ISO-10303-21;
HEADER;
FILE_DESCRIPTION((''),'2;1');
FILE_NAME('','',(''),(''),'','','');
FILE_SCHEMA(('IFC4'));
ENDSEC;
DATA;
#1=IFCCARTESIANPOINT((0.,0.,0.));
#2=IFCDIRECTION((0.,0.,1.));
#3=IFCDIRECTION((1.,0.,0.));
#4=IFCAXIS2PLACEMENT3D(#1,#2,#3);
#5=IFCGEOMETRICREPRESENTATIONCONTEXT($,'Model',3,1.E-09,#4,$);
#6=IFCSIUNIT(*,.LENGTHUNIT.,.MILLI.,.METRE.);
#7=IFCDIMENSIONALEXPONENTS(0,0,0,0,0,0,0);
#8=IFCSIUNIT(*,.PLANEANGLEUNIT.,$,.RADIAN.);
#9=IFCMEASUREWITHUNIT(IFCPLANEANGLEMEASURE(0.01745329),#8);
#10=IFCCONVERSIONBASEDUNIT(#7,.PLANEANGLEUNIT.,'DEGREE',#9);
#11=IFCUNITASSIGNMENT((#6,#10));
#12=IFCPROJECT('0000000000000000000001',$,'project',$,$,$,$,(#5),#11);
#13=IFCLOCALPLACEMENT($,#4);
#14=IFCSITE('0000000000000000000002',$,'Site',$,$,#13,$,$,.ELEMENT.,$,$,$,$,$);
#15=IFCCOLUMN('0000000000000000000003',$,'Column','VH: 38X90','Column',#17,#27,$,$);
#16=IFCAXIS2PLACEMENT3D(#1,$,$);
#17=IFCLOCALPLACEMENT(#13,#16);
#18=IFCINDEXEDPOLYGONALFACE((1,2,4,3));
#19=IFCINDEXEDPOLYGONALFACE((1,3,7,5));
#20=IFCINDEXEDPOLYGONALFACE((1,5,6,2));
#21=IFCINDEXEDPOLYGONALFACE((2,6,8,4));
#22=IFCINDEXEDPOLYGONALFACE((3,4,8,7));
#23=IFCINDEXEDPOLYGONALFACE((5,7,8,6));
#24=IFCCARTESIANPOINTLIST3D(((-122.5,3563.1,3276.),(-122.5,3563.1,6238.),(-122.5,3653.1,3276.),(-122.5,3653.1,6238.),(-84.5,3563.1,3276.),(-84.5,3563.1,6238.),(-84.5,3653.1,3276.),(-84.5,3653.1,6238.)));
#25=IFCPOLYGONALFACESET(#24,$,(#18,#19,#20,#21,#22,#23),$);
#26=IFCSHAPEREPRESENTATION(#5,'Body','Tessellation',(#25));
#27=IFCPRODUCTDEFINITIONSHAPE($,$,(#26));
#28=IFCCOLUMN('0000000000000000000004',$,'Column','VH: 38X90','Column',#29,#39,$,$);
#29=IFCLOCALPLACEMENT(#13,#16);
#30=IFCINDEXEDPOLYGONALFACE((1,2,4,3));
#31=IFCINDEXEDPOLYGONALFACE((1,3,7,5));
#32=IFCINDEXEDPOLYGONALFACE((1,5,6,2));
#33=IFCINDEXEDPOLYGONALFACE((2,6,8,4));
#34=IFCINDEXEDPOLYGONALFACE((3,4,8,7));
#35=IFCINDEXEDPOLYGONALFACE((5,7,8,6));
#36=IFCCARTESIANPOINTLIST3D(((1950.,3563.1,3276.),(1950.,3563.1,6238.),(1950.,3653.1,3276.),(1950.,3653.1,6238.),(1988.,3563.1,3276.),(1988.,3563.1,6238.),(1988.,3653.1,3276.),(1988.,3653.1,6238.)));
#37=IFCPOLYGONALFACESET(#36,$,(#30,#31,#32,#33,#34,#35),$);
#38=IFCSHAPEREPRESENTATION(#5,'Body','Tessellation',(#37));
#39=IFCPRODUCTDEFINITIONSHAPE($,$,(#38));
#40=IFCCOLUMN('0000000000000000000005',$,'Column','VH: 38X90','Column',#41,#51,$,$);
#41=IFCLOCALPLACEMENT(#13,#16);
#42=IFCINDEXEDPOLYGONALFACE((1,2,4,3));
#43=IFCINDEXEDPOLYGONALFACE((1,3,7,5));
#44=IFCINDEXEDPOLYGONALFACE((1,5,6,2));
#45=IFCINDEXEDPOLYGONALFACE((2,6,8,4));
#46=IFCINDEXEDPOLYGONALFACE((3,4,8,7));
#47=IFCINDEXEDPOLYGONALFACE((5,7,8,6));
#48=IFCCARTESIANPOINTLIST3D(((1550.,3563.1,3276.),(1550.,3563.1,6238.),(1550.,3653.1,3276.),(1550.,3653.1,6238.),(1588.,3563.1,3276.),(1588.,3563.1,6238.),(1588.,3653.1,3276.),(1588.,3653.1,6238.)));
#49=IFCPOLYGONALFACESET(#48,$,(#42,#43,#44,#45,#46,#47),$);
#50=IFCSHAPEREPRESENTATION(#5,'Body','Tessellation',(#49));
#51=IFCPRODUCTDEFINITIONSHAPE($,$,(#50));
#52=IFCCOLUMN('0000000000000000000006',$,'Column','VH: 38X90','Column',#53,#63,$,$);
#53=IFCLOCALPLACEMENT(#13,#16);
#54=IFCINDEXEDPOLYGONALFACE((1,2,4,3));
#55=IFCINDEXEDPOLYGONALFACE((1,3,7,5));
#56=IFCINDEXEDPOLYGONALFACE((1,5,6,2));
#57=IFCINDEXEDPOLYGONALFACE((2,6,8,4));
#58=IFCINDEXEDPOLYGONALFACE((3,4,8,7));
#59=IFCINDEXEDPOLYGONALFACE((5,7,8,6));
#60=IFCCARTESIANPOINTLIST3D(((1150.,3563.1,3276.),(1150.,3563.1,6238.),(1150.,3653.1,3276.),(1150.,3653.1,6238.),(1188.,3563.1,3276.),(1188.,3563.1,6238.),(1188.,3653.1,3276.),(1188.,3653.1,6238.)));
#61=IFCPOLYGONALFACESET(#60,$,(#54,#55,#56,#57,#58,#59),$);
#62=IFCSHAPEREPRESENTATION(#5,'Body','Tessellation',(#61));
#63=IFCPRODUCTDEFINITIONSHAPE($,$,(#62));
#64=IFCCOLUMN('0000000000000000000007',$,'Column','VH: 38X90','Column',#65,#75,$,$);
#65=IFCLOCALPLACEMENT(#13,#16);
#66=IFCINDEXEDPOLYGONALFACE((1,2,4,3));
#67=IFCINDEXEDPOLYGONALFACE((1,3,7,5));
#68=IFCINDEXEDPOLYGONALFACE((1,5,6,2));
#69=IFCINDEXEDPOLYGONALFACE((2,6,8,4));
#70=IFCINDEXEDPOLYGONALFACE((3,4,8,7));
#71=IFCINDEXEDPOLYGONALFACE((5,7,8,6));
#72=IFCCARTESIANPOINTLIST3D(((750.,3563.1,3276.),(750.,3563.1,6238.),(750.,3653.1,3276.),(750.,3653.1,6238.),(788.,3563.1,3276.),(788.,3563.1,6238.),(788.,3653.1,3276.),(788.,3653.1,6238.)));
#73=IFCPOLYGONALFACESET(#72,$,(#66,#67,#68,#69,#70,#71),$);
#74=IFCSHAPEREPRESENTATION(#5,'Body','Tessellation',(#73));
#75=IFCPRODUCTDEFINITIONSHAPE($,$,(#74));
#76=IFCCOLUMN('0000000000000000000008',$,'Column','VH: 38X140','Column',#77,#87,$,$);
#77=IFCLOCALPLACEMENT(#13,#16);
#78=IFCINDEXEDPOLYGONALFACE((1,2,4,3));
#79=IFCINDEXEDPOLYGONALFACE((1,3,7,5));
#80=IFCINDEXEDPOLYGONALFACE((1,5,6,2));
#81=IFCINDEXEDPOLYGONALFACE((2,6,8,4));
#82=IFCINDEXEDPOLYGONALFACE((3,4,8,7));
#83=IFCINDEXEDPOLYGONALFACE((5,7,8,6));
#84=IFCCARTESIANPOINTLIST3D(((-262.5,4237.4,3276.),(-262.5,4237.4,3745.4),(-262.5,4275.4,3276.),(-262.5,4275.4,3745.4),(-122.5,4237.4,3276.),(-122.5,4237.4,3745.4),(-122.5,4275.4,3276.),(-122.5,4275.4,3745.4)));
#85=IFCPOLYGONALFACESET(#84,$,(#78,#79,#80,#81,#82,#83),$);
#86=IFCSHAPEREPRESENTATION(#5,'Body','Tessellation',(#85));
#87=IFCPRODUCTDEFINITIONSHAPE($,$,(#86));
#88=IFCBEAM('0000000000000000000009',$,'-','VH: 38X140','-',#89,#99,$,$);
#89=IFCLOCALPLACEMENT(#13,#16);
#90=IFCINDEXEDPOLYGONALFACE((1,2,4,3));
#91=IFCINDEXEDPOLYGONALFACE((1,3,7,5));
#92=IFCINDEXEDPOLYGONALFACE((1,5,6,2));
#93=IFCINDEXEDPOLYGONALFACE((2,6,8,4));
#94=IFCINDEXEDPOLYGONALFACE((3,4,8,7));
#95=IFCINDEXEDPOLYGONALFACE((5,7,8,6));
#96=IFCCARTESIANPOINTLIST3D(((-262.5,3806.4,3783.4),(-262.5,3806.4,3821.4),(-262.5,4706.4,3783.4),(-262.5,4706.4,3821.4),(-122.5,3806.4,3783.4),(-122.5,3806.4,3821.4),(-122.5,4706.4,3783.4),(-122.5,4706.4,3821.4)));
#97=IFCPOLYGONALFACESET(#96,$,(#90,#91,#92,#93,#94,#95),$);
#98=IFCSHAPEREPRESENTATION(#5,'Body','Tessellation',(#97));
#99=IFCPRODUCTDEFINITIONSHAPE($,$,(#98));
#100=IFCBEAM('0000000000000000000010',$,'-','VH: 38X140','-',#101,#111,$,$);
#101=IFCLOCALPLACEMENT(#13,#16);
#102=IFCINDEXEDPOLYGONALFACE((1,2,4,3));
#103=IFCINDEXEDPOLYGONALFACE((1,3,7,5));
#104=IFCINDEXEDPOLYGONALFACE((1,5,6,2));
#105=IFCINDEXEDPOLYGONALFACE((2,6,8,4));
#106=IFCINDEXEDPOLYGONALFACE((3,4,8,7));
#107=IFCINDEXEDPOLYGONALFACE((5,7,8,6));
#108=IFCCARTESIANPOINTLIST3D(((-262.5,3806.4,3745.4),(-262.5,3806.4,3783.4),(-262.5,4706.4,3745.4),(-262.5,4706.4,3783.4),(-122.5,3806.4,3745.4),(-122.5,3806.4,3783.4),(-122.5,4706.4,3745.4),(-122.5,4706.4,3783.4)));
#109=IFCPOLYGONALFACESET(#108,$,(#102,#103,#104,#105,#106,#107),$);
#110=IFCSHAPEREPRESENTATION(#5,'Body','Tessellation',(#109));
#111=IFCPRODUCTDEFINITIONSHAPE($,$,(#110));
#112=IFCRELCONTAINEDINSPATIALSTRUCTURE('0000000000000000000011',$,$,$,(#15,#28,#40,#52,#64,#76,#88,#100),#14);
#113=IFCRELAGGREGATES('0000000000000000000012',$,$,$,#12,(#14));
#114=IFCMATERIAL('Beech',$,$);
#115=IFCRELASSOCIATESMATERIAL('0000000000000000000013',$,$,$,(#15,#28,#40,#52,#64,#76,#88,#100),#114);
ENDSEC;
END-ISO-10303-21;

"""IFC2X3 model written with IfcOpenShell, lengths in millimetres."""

from ifc_helpers import new_model, entity, si_unit, converted_unit, frame, origin, origin_with_axes, origin_2d, place, context, project, spatial, rectangle, extrude, material, element, save


model = new_model("IFC2X3")

# Units and contexts
model_context = context("Model", 3, precision=1e-09, world=origin_with_axes())
ifc_project = project(units=[si_unit("LENGTHUNIT", "METRE", prefix="MILLI"), converted_unit("PLANEANGLEUNIT", "DEGREE", entity("IfcPlaneAngleMeasure", 0.01745329), si_unit("PLANEANGLEUNIT", "RADIAN"), dimensions=[0, 0, 0, 0, 0, 0, 0])], contexts=[model_context])

# Site
site_placement = place(None, origin_with_axes())
site = spatial("IfcSite", under=ifc_project, at=site_placement, Name="Site", CompositionType="ELEMENT")

# Columns
ifc_material = material(Name="Beech")
for number, where, z_axis, x_axis, name in (
    (1, (-103.5, 3608.1, 3276.0), (0.0, 0.0, -1.0), (-1.0, 0.0, 0.0), "Column"),
    (2, (1969.0, 3608.1, 3276.0), (0.0, 0.0, -1.0), (-1.0, 0.0, 0.0), "Column"),
    (3, (1569.0, 3608.1, 3276.0), (0.0, 0.0, -1.0), (-1.0, 0.0, 0.0), "Column"),
    (4, (1169.0, 3608.1, 3276.0), (0.0, 0.0, -1.0), (-1.0, 0.0, 0.0), "Column"),
    (5, (769.0, 3608.1, 3276.0), (0.0, 0.0, -1.0), (-1.0, 0.0, 0.0), "Column"),
):
    element("IfcColumn", number, at=place(None, frame(where, z_axis=z_axis, x_axis=x_axis)), inside=site, material=ifc_material, Name=name, Description="VH: 38X90", ObjectType="Column", context=model_context, shape_type="SweptSolid", body=[
        extrude(rectangle(XDim=38.0, YDim=90.0, at=origin_2d()), origin(), (0.0, 0.0, -1.0), 2962.0),
    ])
column_1_placement = place(None, frame((-192.5, 4256.4, 3276.0), z_axis=(0.0, 0.0, -1.0), x_axis=(0.0, -1.0, 0.0)))
element("IfcColumn", 6, at=column_1_placement, inside=site, material=ifc_material, Name="Column", Description="VH: 38X140", ObjectType="Column", context=model_context, shape_type="SweptSolid", body=[
    extrude(rectangle(XDim=38.0, YDim=140.0, at=origin_2d()), origin(), (0.0, 0.0, -1.0), 469.4),
])

# Beams
for number, where, z_axis, x_axis, name in (
    (7, (-192.5, 4706.4, 3802.4), (0.0, 1.0, 0.0), (0.0, 0.0, -1.0), "-"),
    (8, (-192.5, 4706.4, 3764.4), (0.0, 1.0, 0.0), (0.0, 0.0, -1.0), "-"),
):
    element("IfcBeam", number, at=place(None, frame(where, z_axis=z_axis, x_axis=x_axis)), inside=site, material=ifc_material, Name=name, Description="VH: 38X140", ObjectType="-", context=model_context, shape_type="SweptSolid", body=[
        extrude(rectangle(XDim=38.0, YDim=140.0, at=origin_2d()), origin(), (0.0, 0.0, -1.0), 900.0),
    ])

save(model, "model.ifc")
